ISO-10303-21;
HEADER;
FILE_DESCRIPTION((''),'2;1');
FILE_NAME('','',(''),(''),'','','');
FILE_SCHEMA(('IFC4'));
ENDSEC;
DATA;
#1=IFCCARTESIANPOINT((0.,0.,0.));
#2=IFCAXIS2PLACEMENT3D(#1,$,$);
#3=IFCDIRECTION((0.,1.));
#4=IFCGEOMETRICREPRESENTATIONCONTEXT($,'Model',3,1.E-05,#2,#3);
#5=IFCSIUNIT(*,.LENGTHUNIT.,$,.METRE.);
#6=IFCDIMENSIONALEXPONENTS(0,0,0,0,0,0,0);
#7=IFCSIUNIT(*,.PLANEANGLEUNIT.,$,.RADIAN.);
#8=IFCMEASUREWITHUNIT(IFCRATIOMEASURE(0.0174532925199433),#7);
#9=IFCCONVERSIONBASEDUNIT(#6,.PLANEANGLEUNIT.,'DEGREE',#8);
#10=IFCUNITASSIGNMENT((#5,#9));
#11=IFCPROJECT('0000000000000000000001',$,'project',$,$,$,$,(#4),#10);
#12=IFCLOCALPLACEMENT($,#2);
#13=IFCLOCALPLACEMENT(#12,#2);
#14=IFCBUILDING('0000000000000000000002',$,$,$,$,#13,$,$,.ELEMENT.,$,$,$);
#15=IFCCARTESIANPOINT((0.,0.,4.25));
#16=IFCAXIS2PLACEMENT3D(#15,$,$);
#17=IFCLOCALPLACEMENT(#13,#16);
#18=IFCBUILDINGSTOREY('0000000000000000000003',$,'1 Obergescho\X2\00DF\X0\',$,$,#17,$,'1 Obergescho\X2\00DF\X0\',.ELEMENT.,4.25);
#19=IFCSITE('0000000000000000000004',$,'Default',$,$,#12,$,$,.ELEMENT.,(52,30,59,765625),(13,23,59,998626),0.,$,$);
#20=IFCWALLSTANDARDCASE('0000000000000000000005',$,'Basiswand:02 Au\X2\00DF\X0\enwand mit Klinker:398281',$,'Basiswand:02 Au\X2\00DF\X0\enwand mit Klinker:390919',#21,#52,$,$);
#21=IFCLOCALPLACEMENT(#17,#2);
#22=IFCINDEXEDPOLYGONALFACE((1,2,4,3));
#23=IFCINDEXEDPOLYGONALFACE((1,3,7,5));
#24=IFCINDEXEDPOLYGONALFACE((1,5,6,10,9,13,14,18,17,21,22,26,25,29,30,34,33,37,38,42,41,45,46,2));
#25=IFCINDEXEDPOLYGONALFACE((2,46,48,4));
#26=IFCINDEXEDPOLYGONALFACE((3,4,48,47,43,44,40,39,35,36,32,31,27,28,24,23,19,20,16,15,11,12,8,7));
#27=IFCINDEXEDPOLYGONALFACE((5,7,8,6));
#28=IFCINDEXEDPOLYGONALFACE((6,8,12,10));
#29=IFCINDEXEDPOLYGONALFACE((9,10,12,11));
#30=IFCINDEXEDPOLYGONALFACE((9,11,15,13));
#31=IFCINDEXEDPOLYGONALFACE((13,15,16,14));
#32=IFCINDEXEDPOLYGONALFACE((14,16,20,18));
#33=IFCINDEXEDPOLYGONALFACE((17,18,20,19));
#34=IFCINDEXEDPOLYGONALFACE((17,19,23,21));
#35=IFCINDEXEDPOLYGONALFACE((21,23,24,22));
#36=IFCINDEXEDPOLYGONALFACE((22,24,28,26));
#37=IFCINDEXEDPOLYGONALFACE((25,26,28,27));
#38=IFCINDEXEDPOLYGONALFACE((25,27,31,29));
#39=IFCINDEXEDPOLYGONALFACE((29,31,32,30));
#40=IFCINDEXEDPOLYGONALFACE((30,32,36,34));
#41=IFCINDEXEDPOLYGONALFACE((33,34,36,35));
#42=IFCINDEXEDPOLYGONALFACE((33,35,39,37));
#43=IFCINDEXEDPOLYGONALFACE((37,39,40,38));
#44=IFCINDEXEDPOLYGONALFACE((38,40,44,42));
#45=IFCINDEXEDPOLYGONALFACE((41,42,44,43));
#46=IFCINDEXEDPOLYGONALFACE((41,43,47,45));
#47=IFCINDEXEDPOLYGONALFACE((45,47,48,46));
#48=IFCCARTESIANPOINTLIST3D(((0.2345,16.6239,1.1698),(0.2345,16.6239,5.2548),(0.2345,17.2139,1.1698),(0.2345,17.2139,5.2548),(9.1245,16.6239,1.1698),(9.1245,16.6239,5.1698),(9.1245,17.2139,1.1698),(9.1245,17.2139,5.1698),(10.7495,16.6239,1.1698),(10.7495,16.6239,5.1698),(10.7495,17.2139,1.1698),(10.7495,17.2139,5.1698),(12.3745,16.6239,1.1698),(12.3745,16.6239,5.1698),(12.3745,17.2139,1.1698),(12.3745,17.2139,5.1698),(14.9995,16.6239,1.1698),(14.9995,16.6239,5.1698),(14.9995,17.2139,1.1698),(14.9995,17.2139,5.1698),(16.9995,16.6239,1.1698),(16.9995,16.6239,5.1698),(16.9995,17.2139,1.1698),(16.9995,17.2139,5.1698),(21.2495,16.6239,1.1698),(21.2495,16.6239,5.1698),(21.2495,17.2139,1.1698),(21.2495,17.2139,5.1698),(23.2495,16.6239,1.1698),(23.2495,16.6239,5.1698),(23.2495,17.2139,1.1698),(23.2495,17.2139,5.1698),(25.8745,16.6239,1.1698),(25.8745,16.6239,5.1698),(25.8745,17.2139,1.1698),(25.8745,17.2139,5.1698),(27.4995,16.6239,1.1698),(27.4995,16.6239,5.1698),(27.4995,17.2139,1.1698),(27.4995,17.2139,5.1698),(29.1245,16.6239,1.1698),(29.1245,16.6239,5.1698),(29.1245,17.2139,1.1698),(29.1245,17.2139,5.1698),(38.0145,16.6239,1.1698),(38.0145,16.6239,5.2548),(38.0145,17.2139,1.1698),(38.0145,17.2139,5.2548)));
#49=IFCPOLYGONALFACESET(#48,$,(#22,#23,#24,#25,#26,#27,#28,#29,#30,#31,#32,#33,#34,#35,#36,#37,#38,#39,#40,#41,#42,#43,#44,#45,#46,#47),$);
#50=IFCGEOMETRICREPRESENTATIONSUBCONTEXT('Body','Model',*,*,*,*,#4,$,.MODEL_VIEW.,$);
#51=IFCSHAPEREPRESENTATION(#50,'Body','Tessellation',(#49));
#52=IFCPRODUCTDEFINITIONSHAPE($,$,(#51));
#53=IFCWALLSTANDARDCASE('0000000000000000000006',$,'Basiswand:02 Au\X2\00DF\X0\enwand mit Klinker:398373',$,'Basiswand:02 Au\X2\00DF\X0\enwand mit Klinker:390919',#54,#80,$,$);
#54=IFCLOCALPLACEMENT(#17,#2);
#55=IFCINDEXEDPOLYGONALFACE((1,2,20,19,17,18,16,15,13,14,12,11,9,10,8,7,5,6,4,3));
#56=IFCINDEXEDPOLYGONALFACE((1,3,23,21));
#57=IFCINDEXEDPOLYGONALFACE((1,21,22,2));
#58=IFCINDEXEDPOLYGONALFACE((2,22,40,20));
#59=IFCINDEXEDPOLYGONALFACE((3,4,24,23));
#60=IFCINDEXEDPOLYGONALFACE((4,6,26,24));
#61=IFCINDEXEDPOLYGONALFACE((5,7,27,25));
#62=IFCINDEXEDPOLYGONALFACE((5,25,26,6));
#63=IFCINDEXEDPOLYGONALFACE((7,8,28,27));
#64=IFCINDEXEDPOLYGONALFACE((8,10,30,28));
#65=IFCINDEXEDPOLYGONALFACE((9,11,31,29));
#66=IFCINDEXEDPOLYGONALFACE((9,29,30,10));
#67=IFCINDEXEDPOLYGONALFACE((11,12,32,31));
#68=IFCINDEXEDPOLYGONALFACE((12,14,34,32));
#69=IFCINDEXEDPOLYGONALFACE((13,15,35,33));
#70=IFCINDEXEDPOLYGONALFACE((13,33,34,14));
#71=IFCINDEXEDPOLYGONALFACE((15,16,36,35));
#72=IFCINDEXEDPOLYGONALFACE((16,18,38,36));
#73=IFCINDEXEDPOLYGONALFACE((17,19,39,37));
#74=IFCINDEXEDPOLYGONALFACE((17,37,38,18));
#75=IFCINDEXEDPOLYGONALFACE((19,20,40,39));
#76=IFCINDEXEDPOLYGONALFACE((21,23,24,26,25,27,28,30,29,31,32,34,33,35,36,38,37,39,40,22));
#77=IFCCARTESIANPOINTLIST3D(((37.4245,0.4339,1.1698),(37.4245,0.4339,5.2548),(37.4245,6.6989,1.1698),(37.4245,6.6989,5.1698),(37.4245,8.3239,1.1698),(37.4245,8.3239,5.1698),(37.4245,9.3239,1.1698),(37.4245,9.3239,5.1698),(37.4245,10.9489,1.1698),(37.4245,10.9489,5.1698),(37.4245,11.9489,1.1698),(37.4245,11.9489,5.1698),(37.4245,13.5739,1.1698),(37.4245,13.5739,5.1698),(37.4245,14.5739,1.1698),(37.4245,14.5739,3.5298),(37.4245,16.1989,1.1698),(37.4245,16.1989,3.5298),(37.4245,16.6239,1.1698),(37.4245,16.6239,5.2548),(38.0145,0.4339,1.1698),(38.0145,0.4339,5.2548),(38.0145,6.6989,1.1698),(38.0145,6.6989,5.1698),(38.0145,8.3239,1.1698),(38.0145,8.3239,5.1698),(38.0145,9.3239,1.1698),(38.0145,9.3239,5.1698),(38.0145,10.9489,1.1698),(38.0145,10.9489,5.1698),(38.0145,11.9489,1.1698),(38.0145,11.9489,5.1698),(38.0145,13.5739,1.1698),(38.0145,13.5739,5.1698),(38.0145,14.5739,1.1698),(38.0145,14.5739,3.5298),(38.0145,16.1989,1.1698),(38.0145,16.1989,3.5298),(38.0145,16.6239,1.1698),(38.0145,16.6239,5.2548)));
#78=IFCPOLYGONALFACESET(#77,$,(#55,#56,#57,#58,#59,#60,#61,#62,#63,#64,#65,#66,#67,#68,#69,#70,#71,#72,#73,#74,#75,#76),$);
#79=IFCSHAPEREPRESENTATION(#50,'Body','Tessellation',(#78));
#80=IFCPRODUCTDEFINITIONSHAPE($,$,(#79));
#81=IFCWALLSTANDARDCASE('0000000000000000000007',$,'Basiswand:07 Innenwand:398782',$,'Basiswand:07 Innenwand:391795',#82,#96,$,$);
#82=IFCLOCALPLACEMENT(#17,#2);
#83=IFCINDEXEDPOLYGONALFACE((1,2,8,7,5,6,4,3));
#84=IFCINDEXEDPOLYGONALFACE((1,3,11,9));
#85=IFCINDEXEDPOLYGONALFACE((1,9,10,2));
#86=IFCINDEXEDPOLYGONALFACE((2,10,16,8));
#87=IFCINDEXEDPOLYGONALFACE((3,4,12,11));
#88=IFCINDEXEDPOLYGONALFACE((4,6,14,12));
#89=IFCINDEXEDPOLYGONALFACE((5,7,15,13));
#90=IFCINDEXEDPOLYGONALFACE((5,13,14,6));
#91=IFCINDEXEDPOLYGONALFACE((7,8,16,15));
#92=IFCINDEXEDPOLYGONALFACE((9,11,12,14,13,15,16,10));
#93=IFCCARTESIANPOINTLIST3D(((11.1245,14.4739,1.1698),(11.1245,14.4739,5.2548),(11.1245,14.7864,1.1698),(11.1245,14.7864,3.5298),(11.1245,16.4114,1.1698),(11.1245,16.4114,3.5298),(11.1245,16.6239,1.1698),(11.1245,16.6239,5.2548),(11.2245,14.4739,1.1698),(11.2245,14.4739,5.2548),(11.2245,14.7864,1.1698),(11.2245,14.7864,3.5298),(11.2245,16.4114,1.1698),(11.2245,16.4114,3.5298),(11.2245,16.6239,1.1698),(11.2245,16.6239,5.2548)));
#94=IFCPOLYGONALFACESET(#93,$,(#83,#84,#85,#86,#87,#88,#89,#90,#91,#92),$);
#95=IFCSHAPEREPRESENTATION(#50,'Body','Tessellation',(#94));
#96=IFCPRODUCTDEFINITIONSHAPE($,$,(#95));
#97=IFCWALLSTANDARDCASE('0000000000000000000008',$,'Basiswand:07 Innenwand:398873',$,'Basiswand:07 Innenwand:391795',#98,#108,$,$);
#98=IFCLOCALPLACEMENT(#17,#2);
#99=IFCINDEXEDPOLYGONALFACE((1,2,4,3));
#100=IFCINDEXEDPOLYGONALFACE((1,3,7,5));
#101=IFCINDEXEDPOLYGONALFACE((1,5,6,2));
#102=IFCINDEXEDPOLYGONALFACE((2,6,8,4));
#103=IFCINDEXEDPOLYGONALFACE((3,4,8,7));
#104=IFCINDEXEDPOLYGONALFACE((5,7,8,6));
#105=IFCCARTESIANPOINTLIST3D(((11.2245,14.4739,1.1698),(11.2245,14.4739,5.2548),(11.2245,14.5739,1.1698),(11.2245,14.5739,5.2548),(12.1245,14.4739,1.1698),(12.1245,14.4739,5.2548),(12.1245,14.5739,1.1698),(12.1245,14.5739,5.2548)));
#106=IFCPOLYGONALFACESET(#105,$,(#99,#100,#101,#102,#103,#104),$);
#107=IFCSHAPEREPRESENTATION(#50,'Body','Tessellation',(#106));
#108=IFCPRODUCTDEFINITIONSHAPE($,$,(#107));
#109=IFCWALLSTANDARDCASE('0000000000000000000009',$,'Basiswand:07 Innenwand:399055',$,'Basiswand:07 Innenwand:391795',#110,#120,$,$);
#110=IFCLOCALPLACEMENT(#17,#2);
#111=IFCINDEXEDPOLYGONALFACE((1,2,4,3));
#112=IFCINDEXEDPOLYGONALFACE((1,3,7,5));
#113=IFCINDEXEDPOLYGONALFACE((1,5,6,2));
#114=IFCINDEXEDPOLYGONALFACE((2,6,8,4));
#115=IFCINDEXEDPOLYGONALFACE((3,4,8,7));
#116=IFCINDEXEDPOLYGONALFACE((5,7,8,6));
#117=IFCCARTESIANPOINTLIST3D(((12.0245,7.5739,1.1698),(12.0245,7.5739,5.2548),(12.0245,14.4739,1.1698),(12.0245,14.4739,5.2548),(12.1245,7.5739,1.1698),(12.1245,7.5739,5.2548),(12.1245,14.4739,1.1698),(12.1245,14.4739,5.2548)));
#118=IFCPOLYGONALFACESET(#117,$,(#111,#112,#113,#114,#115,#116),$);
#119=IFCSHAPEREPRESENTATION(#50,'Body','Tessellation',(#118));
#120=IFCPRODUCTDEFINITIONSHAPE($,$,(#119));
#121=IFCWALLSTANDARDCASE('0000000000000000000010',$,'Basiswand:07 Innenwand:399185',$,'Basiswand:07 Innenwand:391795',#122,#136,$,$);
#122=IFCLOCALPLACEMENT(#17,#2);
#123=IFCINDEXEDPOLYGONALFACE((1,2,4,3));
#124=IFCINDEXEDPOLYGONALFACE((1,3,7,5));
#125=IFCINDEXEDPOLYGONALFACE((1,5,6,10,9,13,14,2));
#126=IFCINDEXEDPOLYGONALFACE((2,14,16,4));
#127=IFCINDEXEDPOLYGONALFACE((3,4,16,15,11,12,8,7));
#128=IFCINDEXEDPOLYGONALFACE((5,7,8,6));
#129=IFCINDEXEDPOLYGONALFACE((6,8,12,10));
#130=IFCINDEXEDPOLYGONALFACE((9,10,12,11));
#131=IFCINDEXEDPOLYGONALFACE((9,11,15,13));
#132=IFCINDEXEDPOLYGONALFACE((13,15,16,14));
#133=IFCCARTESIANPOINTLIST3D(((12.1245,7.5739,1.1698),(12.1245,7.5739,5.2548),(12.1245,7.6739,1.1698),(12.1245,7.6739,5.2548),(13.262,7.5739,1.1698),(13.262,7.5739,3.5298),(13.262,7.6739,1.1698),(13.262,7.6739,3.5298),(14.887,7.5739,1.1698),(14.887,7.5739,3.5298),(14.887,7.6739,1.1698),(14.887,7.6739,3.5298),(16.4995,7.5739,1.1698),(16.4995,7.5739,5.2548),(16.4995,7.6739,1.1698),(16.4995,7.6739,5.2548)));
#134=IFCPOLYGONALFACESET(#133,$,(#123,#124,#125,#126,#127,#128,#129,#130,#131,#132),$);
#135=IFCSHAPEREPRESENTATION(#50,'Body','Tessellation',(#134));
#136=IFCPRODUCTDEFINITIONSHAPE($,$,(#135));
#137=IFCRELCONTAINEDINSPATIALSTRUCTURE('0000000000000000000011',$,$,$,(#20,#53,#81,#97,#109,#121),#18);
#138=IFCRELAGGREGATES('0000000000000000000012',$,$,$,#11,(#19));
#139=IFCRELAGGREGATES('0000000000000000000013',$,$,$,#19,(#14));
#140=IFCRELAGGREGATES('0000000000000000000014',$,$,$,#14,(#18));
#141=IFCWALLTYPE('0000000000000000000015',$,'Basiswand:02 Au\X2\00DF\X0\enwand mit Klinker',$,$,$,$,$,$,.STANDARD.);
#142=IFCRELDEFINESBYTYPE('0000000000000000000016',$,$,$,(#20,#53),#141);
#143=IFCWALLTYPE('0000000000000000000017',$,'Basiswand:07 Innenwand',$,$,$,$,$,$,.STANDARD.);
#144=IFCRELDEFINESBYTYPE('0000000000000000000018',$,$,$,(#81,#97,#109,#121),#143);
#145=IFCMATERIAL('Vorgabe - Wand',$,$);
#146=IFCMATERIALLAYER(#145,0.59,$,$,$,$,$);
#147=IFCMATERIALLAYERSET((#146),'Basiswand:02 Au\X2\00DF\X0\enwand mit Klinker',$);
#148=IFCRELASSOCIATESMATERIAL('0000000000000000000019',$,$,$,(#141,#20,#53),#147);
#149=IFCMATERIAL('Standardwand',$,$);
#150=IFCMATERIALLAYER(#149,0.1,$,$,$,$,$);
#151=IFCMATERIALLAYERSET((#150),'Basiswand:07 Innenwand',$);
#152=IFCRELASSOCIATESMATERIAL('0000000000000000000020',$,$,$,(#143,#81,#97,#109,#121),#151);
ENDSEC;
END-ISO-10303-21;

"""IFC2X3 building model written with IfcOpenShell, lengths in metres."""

from ifc_helpers import new_model, entity, si_unit, converted_unit, direction, frame, frame_2d, origin, place, context, subcontext, project, spatial, polyline, rectangle, extrude, clip, bounded_halfspace, material, layer, layer_set, layer_usage, type_object, element, save


model = new_model("IFC2X3")

# Units and contexts
model_context = context("Model", 3, precision=1e-05, world=origin(), true_north=direction((0.0, 1.0)))
body_context = subcontext(model_context, "Body", "Model", "MODEL_VIEW")
ifc_project = project(units=[si_unit("LENGTHUNIT", "METRE"), converted_unit("PLANEANGLEUNIT", "DEGREE", entity("IfcRatioMeasure", 0.0174532925199433), si_unit("PLANEANGLEUNIT", "RADIAN"), dimensions=[0, 0, 0, 0, 0, 0, 0])], contexts=[model_context])

# Site, building, storey
site_placement = place(None, origin())
site = spatial("IfcSite", under=ifc_project, at=site_placement, Name="Default", CompositionType="ELEMENT", RefLatitude=(52, 30, 59, 765625), RefLongitude=(13, 23, 59, 998626), RefElevation=0.0)
building_placement = place(site_placement, origin())
building = spatial("IfcBuilding", under=site, at=building_placement, CompositionType="ELEMENT")
storey_placement = place(building_placement, frame((0.0, 0.0, 4.25)))
storey = spatial("IfcBuildingStorey", under=building, at=storey_placement, Name="1 Obergeschoß", LongName="1 Obergeschoß", CompositionType="ELEMENT", Elevation=4.25)

# Walls, openings
ifc_material_1 = material(Name="Vorgabe - Wand")
ifc_layer_1 = layer(ifc_material_1, 0.59)
ifc_layer_set_1 = layer_set([ifc_layer_1], Name="Basiswand:02 Außenwand mit Klinker")
ifc_layer_usage_1 = layer_usage(ifc_layer_set_1, "AXIS2", "NEGATIVE", 0.295)
wall_type_1 = type_object("IfcWallType", Name="Basiswand:02 Außenwand mit Klinker", PredefinedType="STANDARD", material=ifc_layer_set_1)
wall_1_placement = place(storey_placement, frame((0.2345, 16.9189, 1.1698), z_axis=(0.0, 0.0, 1.0), x_axis=(1.0, 0.0, 0.0)))
wall_1 = element("IfcWallStandardCase", 1, at=wall_1_placement, inside=storey, type_object=wall_type_1, material=ifc_layer_usage_1, Name="Basiswand:02 Außenwand mit Klinker:398281", ObjectType="Basiswand:02 Außenwand mit Klinker:390919", context=body_context, shape_type="Clipping", body=[
    clip(extrude(rectangle(XDim=37.78, YDim=0.59, at=frame_2d((18.89, 0.0), x_axis=(-1.0, 0.0))), origin(), (0.0, 0.0, 1.0), 4.085), bounded_halfspace(frame((0.0, -0.295, 4.085), z_axis=(0.0, 0.0, -1.0), x_axis=(0.0, -1.0, 0.0)), True, frame((0.0, -0.295, 4.085)), polyline([(0.0, 0.0), (0.59, 0.0), (10.89, 0.0), (10.99, 0.0), (37.19, 0.0), (37.78, 0.0), (37.78, 0.59), (0.0, 0.59), (0.0, 0.0)]))),
])
opening_1_placement = place(wall_1_placement, frame((12.14, -0.295, 0.0)))
element("IfcOpeningElement", 2, at=opening_1_placement, cuts=wall_1, ObjectType="Opening", context=body_context, shape_type="SweptSolid", body=[
    extrude(rectangle(XDim=4.0, YDim=2.625, at=frame_2d((2.0, 1.3125), x_axis=(1.0, 0.0))), frame((0.0, 0.0, 0.0), z_axis=(0.0, 1.0, 0.0), x_axis=(0.0, 0.0, 1.0)), (0.0, 0.0, 1.0), 0.59),
])
opening_2_placement = place(wall_1_placement, frame((23.015, -0.295, 0.0)))
element("IfcOpeningElement", 3, at=opening_2_placement, cuts=wall_1, ObjectType="Opening", context=body_context, shape_type="SweptSolid", body=[
    extrude(rectangle(XDim=4.0, YDim=2.625, at=frame_2d((2.0, 1.3125), x_axis=(1.0, 0.0))), frame((0.0, 0.0, 0.0), z_axis=(0.0, 1.0, 0.0), x_axis=(0.0, 0.0, 1.0)), (0.0, 0.0, 1.0), 0.59),
])
opening_3_placement = place(wall_1_placement, frame((8.89, -0.295, 0.0)))
element("IfcOpeningElement", 4, at=opening_3_placement, cuts=wall_1, ObjectType="Opening", context=body_context, shape_type="SweptSolid", body=[
    extrude(rectangle(XDim=4.0, YDim=1.625, at=frame_2d((2.0, 0.8125), x_axis=(1.0, 0.0))), frame((0.0, 0.0, 0.0), z_axis=(0.0, 1.0, 0.0), x_axis=(0.0, 0.0, 1.0)), (0.0, 0.0, 1.0), 0.59),
])
opening_4_placement = place(wall_1_placement, frame((27.265, -0.295, 0.0)))
element("IfcOpeningElement", 5, at=opening_4_placement, cuts=wall_1, ObjectType="Opening", context=body_context, shape_type="SweptSolid", body=[
    extrude(rectangle(XDim=4.0, YDim=1.625, at=frame_2d((2.0, 0.8125), x_axis=(1.0, 0.0))), frame((0.0, 0.0, 0.0), z_axis=(0.0, 1.0, 0.0), x_axis=(0.0, 0.0, 1.0)), (0.0, 0.0, 1.0), 0.59),
])
opening_5_placement = place(wall_1_placement, frame((16.765, -0.295, 0.0)))
element("IfcOpeningElement", 6, at=opening_5_placement, cuts=wall_1, ObjectType="Opening", context=body_context, shape_type="SweptSolid", body=[
    extrude(rectangle(XDim=4.0, YDim=4.25, at=frame_2d((2.0, 2.125), x_axis=(1.0, 0.0))), frame((0.0, 0.0, 0.0), z_axis=(0.0, 1.0, 0.0), x_axis=(0.0, 0.0, 1.0)), (0.0, 0.0, 1.0), 0.59),
])
ifc_layer_usage_2 = layer_usage(ifc_layer_set_1, "AXIS2", "NEGATIVE", 0.295)
wall_2_placement = place(storey_placement, frame((37.7195, 16.6239, 1.1698), z_axis=(0.0, 0.0, 1.0), x_axis=(0.0, -1.0, 0.0)))
wall_2 = element("IfcWallStandardCase", 7, at=wall_2_placement, inside=storey, type_object=wall_type_1, material=ifc_layer_usage_2, Name="Basiswand:02 Außenwand mit Klinker:398373", ObjectType="Basiswand:02 Außenwand mit Klinker:390919", context=body_context, shape_type="Clipping", body=[
    clip(extrude(rectangle(XDim=16.19, YDim=0.59, at=frame_2d((8.095, 0.0), x_axis=(-1.0, 0.0))), origin(), (0.0, 0.0, 1.0), 4.085), bounded_halfspace(frame((0.0, -0.295, 4.085), z_axis=(0.0, 0.0, -1.0), x_axis=(1.0, 0.0, 0.0)), True, frame((0.0, -0.295, 4.085)), polyline([(0.0, 0.0), (15.6, 0.0), (16.19, 0.0), (16.19, 0.59), (0.0, 0.59), (0.0, 0.0)]))),
])
opening_6_placement = place(wall_2_placement, frame((2.05, 0.295, 0.0)))
element("IfcOpeningElement", 8, at=opening_6_placement, cuts=wall_2, ObjectType="Opening", context=body_context, shape_type="SweptSolid", body=[
    extrude(rectangle(XDim=2.36, YDim=1.625, at=frame_2d((1.18, 0.8125), x_axis=(1.0, 0.0))), frame((0.0, 0.0, 0.0), z_axis=(0.0, -1.0, 0.0), x_axis=(0.0, 0.0, 1.0)), (0.0, 0.0, 1.0), 0.59),
])
opening_7_placement = place(wall_2_placement, frame((3.05, -0.295, 0.0)))
element("IfcOpeningElement", 9, at=opening_7_placement, cuts=wall_2, ObjectType="Opening", context=body_context, shape_type="SweptSolid", body=[
    extrude(rectangle(XDim=4.0, YDim=1.625, at=frame_2d((2.0, 0.8125), x_axis=(1.0, 0.0))), frame((0.0, 0.0, 0.0), z_axis=(0.0, 1.0, 0.0), x_axis=(0.0, 0.0, 1.0)), (0.0, 0.0, 1.0), 0.59),
])
opening_8_placement = place(wall_2_placement, frame((5.675, -0.295, 0.0)))
element("IfcOpeningElement", 10, at=opening_8_placement, cuts=wall_2, ObjectType="Opening", context=body_context, shape_type="SweptSolid", body=[
    extrude(rectangle(XDim=4.0, YDim=1.625, at=frame_2d((2.0, 0.8125), x_axis=(1.0, 0.0))), frame((0.0, 0.0, 0.0), z_axis=(0.0, 1.0, 0.0), x_axis=(0.0, 0.0, 1.0)), (0.0, 0.0, 1.0), 0.59),
])
opening_9_placement = place(wall_2_placement, frame((8.3, -0.295, 0.0)))
element("IfcOpeningElement", 11, at=opening_9_placement, cuts=wall_2, ObjectType="Opening", context=body_context, shape_type="SweptSolid", body=[
    extrude(rectangle(XDim=4.0, YDim=1.625, at=frame_2d((2.0, 0.8125), x_axis=(1.0, 0.0))), frame((0.0, 0.0, 0.0), z_axis=(0.0, 1.0, 0.0), x_axis=(0.0, 0.0, 1.0)), (0.0, 0.0, 1.0), 0.59),
])

# Wall, opening
ifc_material_2 = material(Name="Standardwand")
ifc_layer_2 = layer(ifc_material_2, 0.1)
ifc_layer_set_2 = layer_set([ifc_layer_2], Name="Basiswand:07 Innenwand")
ifc_layer_usage_3 = layer_usage(ifc_layer_set_2, "AXIS2", "POSITIVE", -0.05)
wall_type_2 = type_object("IfcWallType", Name="Basiswand:07 Innenwand", PredefinedType="STANDARD", material=ifc_layer_set_2)
wall_3_placement = place(storey_placement, frame((11.1745, 16.6239, 1.1698), z_axis=(0.0, 0.0, 1.0), x_axis=(0.0, -1.0, 0.0)))
wall_3 = element("IfcWallStandardCase", 12, at=wall_3_placement, inside=storey, type_object=wall_type_2, material=ifc_layer_usage_3, Name="Basiswand:07 Innenwand:398782", ObjectType="Basiswand:07 Innenwand:391795", context=body_context, shape_type="Clipping", body=[
    clip(extrude(rectangle(XDim=2.15, YDim=0.1, at=frame_2d((1.075, 0.0), x_axis=(-1.0, 0.0))), origin(), (0.0, 0.0, 1.0), 4.085), bounded_halfspace(frame((0.0, -0.05, 4.085), z_axis=(0.0, 0.0, -1.0), x_axis=(1.0, 0.0, 0.0)), True, frame((0.0, -0.05, 4.085)), polyline([(0.0, 0.0), (2.15, 0.0), (2.15, 0.1), (2.05, 0.1), (0.0, 0.1), (0.0, 0.0)]))),
])
opening_10_placement = place(wall_3_placement, frame((0.2125, -0.05, 0.0)))
element("IfcOpeningElement", 13, at=opening_10_placement, cuts=wall_3, ObjectType="Opening", context=body_context, shape_type="SweptSolid", body=[
    extrude(rectangle(XDim=2.36, YDim=1.625, at=frame_2d((1.18, 0.8125), x_axis=(1.0, 0.0))), frame((0.0, 0.0, 0.0), z_axis=(0.0, 1.0, 0.0), x_axis=(0.0, 0.0, 1.0)), (0.0, 0.0, 1.0), 0.1),
])

# Walls
ifc_layer_usage_4 = layer_usage(ifc_layer_set_2, "AXIS2", "POSITIVE", -0.05)
wall_4_placement = place(storey_placement, frame((11.2245, 14.5239, 1.1698), z_axis=(0.0, 0.0, 1.0), x_axis=(1.0, 0.0, 0.0)))
element("IfcWallStandardCase", 14, at=wall_4_placement, inside=storey, type_object=wall_type_2, material=ifc_layer_usage_4, Name="Basiswand:07 Innenwand:398873", ObjectType="Basiswand:07 Innenwand:391795", context=body_context, shape_type="Clipping", body=[
    clip(extrude(rectangle(XDim=0.9, YDim=0.1, at=frame_2d((0.45, 0.0), x_axis=(-1.0, 0.0))), origin(), (0.0, 0.0, 1.0), 4.085), bounded_halfspace(frame((0.0, -0.05, 4.085), z_axis=(0.0, 0.0, -1.0), x_axis=(0.0, -1.0, 0.0)), True, frame((0.0, -0.05, 4.085)), polyline([(0.0, 0.0), (0.8, 0.0), (0.9, 0.0), (0.9, 0.1), (0.0, 0.1), (0.0, 0.0)]))),
])
ifc_layer_usage_5 = layer_usage(ifc_layer_set_2, "AXIS2", "POSITIVE", -0.05)
wall_5_placement = place(storey_placement, frame((12.0745, 14.4739, 1.1698), z_axis=(0.0, 0.0, 1.0), x_axis=(0.0, -1.0, 0.0)))
element("IfcWallStandardCase", 15, at=wall_5_placement, inside=storey, type_object=wall_type_2, material=ifc_layer_usage_5, Name="Basiswand:07 Innenwand:399055", ObjectType="Basiswand:07 Innenwand:391795", context=body_context, shape_type="Clipping", body=[
    clip(extrude(rectangle(XDim=6.9, YDim=0.1, at=frame_2d((3.45, 0.0), x_axis=(-1.0, 0.0))), origin(), (0.0, 0.0, 1.0), 4.085), bounded_halfspace(frame((0.0, -0.05, 4.085), z_axis=(0.0, 0.0, -1.0), x_axis=(1.0, 0.0, 0.0)), True, frame((0.0, -0.05, 4.085)), polyline([(0.0, 0.0), (6.8, 0.0), (6.9, 0.0), (6.9, 0.1), (6.8, 0.1), (0.0, 0.1), (0.0, 0.0)]))),
])

# Wall, opening
ifc_layer_usage_6 = layer_usage(ifc_layer_set_2, "AXIS2", "POSITIVE", -0.05)
wall_6_placement = place(storey_placement, frame((12.1245, 7.6239, 1.1698), z_axis=(0.0, 0.0, 1.0), x_axis=(1.0, 0.0, 0.0)))
wall_6 = element("IfcWallStandardCase", 16, at=wall_6_placement, inside=storey, type_object=wall_type_2, material=ifc_layer_usage_6, Name="Basiswand:07 Innenwand:399185", ObjectType="Basiswand:07 Innenwand:391795", context=body_context, shape_type="Clipping", body=[
    clip(extrude(rectangle(XDim=4.375, YDim=0.1, at=frame_2d((2.1875, 0.0), x_axis=(-1.0, 0.0))), origin(), (0.0, 0.0, 1.0), 4.085), bounded_halfspace(frame((0.0, -0.05, 4.085), z_axis=(0.0, 0.0, -1.0), x_axis=(0.0, -1.0, 0.0)), True, frame((0.0, -0.05, 4.085)), polyline([(0.0, 0.0), (0.65, 0.0), (0.75, 0.0), (2.875, 0.0), (2.975, 0.0), (4.375, 0.0), (4.375, 0.1), (0.0, 0.1), (0.0, 0.0)]))),
])
opening_11_placement = place(wall_6_placement, frame((2.7625, 0.05, 0.0)))
element("IfcOpeningElement", 17, at=opening_11_placement, cuts=wall_6, ObjectType="Opening", context=body_context, shape_type="SweptSolid", body=[
    extrude(rectangle(XDim=2.36, YDim=1.625, at=frame_2d((1.18, 0.8125), x_axis=(1.0, 0.0))), frame((0.0, 0.0, 0.0), z_axis=(0.0, -1.0, 0.0), x_axis=(0.0, 0.0, 1.0)), (0.0, 0.0, 1.0), 0.1),
])

save(model, "model.ifc")
